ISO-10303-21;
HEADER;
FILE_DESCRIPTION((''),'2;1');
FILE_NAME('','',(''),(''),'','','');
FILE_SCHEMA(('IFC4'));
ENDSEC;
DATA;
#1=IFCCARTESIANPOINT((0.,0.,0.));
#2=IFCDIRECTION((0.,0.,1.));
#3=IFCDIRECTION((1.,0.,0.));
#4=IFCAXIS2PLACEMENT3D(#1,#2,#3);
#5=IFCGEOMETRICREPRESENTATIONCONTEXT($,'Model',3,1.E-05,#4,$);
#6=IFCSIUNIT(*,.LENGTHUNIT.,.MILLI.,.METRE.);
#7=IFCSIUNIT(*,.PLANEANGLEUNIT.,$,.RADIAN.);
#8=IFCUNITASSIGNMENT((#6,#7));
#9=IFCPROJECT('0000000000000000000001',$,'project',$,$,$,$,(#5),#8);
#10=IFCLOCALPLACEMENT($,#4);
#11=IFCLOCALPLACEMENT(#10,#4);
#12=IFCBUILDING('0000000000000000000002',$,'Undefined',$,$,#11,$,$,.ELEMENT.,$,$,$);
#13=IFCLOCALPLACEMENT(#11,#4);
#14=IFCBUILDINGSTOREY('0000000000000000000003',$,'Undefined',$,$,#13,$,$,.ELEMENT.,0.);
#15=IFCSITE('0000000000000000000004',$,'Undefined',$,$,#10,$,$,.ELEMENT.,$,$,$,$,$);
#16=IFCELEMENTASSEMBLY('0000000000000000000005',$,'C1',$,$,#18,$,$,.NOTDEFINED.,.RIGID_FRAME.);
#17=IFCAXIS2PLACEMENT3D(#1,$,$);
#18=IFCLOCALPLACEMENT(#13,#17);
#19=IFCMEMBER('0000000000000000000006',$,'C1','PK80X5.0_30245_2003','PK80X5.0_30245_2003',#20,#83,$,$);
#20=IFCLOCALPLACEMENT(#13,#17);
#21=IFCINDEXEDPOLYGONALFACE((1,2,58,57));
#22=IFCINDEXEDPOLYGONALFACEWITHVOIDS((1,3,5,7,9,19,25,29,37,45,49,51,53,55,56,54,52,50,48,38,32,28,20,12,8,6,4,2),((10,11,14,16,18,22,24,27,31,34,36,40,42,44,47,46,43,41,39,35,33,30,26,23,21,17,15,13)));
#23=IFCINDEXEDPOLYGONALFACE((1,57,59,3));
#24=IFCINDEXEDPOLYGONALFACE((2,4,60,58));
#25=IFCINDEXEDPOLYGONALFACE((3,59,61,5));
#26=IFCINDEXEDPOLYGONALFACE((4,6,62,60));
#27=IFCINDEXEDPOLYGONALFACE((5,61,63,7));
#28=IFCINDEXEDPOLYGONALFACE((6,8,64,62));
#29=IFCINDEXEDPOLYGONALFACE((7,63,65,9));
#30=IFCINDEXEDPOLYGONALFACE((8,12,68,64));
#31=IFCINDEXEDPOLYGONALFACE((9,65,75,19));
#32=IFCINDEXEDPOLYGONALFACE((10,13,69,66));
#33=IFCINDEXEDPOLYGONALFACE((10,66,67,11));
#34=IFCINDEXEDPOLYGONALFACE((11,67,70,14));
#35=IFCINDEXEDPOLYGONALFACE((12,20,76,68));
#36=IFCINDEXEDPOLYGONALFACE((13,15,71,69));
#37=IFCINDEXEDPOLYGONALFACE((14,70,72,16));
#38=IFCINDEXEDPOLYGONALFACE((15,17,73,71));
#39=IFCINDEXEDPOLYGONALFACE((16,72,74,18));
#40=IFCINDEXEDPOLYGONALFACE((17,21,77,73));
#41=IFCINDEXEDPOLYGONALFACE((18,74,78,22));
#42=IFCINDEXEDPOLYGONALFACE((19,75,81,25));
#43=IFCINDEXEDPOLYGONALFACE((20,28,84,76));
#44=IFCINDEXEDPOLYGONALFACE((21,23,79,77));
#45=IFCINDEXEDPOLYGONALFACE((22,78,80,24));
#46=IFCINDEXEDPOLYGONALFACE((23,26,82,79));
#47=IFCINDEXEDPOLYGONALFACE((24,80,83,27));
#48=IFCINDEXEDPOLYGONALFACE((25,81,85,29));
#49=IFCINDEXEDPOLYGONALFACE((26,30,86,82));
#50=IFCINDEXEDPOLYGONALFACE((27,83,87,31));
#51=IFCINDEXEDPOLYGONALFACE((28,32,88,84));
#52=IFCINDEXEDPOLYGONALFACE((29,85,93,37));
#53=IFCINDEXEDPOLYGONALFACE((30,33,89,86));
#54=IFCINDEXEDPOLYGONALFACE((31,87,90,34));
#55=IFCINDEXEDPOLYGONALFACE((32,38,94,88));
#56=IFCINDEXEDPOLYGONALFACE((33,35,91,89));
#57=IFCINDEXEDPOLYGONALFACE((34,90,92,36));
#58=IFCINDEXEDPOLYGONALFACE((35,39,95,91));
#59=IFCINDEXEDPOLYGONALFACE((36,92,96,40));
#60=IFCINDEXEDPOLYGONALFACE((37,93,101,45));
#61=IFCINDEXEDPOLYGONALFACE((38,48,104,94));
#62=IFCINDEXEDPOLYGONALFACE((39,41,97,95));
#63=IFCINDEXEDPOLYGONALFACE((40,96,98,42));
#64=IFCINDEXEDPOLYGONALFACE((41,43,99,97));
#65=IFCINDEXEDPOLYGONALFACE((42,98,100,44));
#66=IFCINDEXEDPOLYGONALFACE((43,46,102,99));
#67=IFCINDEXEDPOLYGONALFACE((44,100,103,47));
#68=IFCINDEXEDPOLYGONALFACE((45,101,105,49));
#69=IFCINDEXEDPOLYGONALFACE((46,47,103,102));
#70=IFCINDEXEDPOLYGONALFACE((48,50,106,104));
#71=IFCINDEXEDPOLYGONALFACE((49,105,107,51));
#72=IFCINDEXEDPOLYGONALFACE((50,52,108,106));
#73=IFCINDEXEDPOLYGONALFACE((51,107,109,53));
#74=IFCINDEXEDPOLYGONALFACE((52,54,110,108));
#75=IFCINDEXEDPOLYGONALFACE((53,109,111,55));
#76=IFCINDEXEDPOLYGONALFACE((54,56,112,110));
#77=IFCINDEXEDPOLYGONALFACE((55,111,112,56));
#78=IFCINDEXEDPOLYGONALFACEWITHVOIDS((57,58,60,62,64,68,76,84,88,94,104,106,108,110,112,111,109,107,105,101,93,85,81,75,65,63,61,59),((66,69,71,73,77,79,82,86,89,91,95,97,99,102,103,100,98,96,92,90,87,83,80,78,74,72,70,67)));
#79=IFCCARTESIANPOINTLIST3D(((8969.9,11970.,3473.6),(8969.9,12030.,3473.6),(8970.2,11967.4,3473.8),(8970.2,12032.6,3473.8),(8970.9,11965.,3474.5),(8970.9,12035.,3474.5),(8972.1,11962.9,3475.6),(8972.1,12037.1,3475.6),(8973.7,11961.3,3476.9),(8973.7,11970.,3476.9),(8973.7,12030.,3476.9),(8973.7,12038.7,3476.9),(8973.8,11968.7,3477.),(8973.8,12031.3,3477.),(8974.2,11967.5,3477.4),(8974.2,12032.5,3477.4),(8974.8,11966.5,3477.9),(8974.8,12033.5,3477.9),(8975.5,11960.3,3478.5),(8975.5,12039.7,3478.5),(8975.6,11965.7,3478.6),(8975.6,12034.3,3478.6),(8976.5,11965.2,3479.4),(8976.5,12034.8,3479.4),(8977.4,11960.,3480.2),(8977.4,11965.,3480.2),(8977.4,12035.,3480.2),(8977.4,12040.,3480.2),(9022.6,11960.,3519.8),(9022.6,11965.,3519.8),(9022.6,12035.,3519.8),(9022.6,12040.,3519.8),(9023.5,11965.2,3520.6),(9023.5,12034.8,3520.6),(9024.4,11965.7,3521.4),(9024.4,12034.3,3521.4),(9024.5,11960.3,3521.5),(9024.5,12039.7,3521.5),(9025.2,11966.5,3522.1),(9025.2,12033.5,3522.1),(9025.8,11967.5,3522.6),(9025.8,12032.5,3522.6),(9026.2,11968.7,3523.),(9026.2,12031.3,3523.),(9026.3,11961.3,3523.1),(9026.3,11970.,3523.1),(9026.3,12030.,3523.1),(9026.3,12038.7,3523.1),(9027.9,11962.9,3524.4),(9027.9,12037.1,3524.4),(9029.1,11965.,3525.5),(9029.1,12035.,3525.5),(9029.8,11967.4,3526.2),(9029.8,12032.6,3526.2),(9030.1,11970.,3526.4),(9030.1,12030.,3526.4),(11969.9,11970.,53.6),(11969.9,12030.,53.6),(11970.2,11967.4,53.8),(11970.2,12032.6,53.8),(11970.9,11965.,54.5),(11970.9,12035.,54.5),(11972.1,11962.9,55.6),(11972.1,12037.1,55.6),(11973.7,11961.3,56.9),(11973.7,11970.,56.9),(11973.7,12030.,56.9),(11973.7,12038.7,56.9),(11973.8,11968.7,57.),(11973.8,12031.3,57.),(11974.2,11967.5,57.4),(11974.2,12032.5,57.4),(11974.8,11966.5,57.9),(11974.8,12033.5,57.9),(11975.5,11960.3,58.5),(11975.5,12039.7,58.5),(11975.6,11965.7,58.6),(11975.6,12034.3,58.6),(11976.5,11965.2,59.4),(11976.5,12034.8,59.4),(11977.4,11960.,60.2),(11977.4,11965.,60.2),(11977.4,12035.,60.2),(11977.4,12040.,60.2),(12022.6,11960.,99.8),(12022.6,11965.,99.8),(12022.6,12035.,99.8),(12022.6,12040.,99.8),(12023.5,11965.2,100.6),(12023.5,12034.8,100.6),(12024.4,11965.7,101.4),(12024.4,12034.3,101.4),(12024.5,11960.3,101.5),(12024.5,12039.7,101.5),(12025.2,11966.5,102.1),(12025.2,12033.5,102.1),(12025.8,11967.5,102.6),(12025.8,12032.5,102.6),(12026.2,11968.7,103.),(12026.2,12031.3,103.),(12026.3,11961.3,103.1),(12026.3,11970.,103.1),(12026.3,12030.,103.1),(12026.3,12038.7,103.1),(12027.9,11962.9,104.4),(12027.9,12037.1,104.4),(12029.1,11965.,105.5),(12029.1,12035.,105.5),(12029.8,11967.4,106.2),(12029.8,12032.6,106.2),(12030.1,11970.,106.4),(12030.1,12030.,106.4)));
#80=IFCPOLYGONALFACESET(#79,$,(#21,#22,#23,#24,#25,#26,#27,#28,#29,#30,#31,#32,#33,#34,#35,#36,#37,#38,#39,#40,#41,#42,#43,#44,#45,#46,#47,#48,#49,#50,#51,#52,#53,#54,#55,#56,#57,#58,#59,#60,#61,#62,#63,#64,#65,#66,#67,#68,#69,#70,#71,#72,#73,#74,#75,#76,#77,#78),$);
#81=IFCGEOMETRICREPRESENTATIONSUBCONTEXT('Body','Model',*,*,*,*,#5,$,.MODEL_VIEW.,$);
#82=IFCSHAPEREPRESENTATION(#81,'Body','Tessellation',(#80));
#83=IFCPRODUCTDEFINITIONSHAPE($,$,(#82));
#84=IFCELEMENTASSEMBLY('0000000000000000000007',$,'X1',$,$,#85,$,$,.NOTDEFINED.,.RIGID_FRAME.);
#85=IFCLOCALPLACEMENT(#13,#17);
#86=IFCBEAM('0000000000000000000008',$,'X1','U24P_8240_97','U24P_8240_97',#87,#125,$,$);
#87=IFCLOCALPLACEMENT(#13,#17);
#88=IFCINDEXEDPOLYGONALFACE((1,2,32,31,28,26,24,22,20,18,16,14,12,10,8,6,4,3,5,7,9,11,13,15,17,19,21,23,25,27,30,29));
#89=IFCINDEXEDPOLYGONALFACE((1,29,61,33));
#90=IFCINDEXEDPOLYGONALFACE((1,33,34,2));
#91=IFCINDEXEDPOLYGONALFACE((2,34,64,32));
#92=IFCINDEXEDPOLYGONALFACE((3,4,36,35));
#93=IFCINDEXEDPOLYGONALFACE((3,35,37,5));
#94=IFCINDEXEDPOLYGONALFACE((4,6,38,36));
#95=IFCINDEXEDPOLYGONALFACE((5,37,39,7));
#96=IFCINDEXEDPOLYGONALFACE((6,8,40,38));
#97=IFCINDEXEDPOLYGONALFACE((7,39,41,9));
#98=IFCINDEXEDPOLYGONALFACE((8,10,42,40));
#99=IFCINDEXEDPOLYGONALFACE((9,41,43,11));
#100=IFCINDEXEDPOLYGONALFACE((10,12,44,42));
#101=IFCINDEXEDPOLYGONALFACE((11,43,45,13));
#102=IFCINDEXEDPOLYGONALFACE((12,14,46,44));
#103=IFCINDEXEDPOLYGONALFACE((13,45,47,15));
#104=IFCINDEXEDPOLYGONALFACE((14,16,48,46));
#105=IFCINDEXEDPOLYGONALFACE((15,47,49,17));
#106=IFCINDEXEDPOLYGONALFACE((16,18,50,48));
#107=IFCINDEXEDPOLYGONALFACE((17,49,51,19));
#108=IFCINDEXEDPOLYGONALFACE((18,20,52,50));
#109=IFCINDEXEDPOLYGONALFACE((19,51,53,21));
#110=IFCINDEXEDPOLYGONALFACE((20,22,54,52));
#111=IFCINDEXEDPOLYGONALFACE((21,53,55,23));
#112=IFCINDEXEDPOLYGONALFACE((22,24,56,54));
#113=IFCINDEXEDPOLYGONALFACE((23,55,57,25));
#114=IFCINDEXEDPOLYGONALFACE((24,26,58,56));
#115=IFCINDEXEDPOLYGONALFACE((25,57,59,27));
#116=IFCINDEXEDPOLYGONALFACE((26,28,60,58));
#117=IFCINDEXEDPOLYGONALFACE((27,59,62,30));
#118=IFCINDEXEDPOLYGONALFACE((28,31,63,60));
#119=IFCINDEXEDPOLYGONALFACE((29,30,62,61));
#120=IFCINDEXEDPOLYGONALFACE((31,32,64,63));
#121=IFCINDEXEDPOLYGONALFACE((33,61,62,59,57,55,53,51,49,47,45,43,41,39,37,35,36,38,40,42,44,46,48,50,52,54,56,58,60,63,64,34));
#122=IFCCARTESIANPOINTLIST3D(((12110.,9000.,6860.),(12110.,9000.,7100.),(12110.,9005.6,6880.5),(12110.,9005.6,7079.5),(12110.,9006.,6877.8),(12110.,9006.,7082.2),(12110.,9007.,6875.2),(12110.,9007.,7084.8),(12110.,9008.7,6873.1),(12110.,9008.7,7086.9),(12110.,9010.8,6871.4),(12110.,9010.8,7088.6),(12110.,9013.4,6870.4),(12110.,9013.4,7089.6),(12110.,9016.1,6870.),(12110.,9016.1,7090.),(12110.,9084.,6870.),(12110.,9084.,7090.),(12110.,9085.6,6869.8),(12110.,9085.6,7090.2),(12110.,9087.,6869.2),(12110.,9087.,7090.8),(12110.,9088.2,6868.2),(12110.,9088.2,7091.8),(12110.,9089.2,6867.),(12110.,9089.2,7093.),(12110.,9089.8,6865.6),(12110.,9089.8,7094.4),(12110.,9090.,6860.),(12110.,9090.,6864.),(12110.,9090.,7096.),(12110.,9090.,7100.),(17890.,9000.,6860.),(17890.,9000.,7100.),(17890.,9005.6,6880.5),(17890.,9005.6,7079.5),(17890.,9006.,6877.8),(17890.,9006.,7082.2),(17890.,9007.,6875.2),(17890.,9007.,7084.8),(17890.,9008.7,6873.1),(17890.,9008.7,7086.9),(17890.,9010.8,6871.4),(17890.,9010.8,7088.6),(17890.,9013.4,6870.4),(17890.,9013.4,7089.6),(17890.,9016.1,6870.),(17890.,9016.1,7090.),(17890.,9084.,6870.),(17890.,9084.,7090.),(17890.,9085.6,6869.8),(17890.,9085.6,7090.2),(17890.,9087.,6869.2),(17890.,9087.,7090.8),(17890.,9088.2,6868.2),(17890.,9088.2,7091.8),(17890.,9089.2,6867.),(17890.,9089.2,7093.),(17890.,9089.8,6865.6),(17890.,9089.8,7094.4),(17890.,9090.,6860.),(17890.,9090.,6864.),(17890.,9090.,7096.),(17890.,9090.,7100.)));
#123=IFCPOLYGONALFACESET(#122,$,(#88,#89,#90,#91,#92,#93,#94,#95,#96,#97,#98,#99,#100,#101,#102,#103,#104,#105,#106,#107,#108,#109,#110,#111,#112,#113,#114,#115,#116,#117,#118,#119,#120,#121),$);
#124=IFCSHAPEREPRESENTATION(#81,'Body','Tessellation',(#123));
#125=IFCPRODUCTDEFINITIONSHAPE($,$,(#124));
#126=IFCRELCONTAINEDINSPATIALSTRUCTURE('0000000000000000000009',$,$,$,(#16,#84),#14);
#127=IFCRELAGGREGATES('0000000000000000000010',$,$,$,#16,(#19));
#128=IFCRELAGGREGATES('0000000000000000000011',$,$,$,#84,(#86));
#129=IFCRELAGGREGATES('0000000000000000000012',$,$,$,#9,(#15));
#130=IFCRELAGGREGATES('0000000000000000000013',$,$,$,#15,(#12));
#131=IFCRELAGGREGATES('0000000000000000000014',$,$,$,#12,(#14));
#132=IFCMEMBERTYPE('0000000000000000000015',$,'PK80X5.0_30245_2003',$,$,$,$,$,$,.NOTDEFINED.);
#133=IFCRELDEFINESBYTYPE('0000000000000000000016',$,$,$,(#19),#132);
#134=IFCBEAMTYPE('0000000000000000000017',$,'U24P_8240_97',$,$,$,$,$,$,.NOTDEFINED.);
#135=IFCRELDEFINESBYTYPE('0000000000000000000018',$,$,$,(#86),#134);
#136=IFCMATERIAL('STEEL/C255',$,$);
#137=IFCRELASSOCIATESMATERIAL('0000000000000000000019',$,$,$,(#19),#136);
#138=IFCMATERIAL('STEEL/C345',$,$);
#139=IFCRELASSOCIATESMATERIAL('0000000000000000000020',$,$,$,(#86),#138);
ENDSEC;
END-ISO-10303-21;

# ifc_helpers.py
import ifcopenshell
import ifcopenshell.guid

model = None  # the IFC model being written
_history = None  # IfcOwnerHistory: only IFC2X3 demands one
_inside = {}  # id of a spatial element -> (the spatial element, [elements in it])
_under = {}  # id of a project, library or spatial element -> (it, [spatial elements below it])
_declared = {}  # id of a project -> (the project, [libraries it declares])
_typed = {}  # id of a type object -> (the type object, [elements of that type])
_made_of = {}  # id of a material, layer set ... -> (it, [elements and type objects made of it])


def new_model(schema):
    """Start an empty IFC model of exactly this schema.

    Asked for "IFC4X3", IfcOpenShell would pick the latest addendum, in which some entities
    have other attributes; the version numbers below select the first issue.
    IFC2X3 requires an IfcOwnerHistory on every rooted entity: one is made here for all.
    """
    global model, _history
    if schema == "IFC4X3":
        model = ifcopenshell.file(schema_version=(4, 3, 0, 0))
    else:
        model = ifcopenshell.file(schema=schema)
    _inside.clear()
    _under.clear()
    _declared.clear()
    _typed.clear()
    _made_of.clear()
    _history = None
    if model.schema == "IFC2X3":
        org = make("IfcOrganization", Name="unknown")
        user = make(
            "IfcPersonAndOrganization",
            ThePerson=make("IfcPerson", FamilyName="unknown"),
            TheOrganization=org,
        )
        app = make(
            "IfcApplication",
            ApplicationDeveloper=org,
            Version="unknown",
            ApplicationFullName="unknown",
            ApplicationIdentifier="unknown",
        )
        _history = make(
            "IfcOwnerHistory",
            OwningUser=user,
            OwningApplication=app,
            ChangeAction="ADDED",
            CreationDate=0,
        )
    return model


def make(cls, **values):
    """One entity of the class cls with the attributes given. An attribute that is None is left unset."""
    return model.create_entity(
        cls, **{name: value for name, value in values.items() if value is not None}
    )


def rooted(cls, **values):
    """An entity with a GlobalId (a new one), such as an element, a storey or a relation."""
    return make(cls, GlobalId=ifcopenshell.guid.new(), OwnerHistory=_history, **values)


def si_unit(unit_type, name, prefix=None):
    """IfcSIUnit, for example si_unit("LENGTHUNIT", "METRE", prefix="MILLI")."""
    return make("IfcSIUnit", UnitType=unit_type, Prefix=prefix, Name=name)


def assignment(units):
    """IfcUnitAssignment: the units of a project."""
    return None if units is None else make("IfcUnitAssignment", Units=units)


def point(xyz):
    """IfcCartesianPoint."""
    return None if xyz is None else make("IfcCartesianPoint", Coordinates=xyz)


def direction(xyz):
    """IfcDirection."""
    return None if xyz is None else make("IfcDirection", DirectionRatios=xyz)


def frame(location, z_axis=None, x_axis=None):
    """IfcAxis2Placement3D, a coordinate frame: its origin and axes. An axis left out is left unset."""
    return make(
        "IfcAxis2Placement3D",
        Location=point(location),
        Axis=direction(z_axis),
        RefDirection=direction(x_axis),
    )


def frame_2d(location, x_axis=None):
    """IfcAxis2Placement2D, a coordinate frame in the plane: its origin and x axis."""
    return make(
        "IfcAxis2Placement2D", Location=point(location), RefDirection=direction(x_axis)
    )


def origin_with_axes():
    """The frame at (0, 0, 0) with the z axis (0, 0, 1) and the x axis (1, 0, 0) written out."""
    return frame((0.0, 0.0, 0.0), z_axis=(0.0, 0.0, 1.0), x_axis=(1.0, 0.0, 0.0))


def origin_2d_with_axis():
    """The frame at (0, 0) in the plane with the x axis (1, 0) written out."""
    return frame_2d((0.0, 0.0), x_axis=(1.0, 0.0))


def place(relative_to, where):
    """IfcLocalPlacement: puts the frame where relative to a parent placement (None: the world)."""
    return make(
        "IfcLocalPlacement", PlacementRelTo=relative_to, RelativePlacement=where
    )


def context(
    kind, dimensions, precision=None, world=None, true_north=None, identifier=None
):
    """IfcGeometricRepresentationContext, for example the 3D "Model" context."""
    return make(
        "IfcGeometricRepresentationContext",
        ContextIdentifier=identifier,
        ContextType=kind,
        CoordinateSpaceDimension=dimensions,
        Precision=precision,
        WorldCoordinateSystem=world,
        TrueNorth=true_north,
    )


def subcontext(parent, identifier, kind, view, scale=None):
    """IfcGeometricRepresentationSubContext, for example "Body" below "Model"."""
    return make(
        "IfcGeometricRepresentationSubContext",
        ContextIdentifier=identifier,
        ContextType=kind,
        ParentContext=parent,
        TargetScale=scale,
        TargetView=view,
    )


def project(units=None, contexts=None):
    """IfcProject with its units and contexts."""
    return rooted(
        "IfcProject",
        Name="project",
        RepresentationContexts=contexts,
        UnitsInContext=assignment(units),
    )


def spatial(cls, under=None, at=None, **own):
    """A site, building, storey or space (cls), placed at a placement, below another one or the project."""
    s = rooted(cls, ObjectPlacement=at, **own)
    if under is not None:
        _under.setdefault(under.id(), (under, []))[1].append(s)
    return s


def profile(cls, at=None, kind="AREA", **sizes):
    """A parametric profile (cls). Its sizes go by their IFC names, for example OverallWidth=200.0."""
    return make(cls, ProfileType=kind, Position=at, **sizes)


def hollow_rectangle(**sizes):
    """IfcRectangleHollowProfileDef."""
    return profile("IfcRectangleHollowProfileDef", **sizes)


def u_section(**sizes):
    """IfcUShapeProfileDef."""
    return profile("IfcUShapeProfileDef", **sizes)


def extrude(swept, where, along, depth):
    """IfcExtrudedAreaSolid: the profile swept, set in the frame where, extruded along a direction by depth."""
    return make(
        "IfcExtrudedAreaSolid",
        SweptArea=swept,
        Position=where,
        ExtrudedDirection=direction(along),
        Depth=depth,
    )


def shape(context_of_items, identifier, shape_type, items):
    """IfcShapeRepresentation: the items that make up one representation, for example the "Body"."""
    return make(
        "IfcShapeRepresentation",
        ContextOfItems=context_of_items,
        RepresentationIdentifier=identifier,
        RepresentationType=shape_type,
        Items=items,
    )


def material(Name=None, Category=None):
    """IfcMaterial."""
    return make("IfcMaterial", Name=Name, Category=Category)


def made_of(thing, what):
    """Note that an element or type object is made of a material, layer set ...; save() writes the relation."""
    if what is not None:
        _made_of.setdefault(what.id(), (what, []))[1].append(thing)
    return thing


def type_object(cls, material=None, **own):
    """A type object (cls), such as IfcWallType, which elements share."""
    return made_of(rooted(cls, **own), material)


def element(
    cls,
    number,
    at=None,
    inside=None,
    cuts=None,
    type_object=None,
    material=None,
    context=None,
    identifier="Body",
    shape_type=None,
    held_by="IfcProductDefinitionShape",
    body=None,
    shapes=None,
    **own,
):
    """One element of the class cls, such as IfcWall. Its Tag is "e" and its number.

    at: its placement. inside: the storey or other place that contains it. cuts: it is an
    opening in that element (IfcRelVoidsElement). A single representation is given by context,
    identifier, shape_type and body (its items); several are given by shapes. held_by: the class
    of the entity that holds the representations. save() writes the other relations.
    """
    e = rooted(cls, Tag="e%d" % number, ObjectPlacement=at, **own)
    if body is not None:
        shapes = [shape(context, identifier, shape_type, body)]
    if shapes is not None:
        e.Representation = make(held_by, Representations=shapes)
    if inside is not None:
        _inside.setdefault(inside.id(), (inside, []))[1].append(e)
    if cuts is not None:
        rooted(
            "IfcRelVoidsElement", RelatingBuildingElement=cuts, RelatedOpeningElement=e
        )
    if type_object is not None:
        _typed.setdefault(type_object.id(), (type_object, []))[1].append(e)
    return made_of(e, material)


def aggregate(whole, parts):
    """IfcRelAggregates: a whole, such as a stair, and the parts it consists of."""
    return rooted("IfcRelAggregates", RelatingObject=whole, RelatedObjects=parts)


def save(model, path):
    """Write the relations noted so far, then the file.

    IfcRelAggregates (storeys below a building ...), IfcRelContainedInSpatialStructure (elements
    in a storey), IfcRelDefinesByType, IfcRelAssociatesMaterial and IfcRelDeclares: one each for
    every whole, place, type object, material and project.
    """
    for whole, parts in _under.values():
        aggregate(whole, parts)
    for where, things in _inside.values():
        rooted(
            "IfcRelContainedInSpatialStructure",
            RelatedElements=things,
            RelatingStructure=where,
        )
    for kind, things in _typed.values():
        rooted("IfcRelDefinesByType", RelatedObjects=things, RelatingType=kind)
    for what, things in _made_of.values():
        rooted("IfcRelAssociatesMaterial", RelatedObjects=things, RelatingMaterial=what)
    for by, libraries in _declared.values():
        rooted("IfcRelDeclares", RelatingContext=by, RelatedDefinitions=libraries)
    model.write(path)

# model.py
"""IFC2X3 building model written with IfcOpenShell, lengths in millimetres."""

from ifc_helpers import new_model, si_unit, frame, origin_with_axes, origin_2d_with_axis, place, context, subcontext, project, spatial, hollow_rectangle, u_section, extrude, material, type_object, element, aggregate, save


model = new_model("IFC2X3")

# Units and contexts
model_context = context("Model", 3, precision=1e-05, world=origin_with_axes())
body_context = subcontext(model_context, "Body", "Model", "MODEL_VIEW")
ifc_project = project(units=[si_unit("LENGTHUNIT", "METRE", prefix="MILLI"), si_unit("PLANEANGLEUNIT", "RADIAN")], contexts=[model_context])

# Site, building, storey
site_placement = place(None, origin_with_axes())
site = spatial("IfcSite", under=ifc_project, at=site_placement, Name="Undefined", CompositionType="ELEMENT")
building_placement = place(site_placement, origin_with_axes())
building = spatial("IfcBuilding", under=site, at=building_placement, Name="Undefined", CompositionType="ELEMENT")
storey_placement = place(building_placement, origin_with_axes())
storey = spatial("IfcBuildingStorey", under=building, at=storey_placement, Name="Undefined", CompositionType="ELEMENT", Elevation=0.0)

# Shared definitions
ifc_material_1 = material(Name="STEEL/C345")

# Shared definitions
ifc_material_2 = material(Name="STEEL/C255")

# Element assembly, member
member_type = type_object("IfcMemberType", Name="PK80X5.0_30245_2003", PredefinedType="NOTDEFINED")
assembly_1_placement = place(storey_placement, origin_with_axes())
assembly_1 = element("IfcElementAssembly", 1, at=assembly_1_placement, inside=storey, Name="C1", AssemblyPlace="NOTDEFINED", PredefinedType="RIGID_FRAME")
member_1_placement = place(assembly_1_placement, frame((12000.0, 12000.0, 80.0), z_axis=(-0.751759, 0.0, -0.659438), x_axis=(-0.659438, 0.0, 0.751759)))
member_1 = element("IfcMember", 2, at=member_1_placement, type_object=member_type, material=ifc_material_2, Name="C1", Description="PK80X5.0_30245_2003", ObjectType="PK80X5.0_30245_2003", context=body_context, shape_type="SweptSolid", body=[
    extrude(hollow_rectangle(XDim=80.0, YDim=80.0, WallThickness=5.0, InnerFilletRadius=5.0, OuterFilletRadius=10.0, at=origin_2d_with_axis()), frame((4549.3, 0.0, 0.0), z_axis=(-1.0, 0.0, 0.0), x_axis=(0.0, -1.0, 0.0)), (0.0, 0.0, 1.0), 4549.3),
])
aggregate(assembly_1, [member_1])

# Element assembly, beam
assembly_2_placement = place(storey_placement, origin_with_axes())
assembly_2 = element("IfcElementAssembly", 3, at=assembly_2_placement, inside=storey, Name="X1", AssemblyPlace="NOTDEFINED", PredefinedType="RIGID_FRAME")
beam_type_1 = type_object("IfcBeamType", Name="U24P_8240_97", PredefinedType="NOTDEFINED")
beam_1_placement = place(assembly_2_placement, frame((12110.0, 9045.0, 6980.0), z_axis=(0.0, 0.0, -1.0), x_axis=(1.0, 0.0, 0.0)))
beam_1 = element("IfcBeam", 4, at=beam_1_placement, type_object=beam_type_1, material=ifc_material_1, Name="X1", Description="U24P_8240_97", ObjectType="U24P_8240_97", context=body_context, shape_type="SweptSolid", body=[
    extrude(u_section(Depth=240.0, FlangeWidth=90.0, WebThickness=5.6, FlangeThickness=10.0, FilletRadius=10.5, EdgeRadius=6.0, at=origin_2d_with_axis()), frame((5780.0, 0.0, 0.0), z_axis=(-1.0, 0.0, 0.0), x_axis=(0.0, -1.0, 0.0)), (0.0, 0.0, 1.0), 5780.0),
])
aggregate(assembly_2, [beam_1])

save(model, "model.ifc")
